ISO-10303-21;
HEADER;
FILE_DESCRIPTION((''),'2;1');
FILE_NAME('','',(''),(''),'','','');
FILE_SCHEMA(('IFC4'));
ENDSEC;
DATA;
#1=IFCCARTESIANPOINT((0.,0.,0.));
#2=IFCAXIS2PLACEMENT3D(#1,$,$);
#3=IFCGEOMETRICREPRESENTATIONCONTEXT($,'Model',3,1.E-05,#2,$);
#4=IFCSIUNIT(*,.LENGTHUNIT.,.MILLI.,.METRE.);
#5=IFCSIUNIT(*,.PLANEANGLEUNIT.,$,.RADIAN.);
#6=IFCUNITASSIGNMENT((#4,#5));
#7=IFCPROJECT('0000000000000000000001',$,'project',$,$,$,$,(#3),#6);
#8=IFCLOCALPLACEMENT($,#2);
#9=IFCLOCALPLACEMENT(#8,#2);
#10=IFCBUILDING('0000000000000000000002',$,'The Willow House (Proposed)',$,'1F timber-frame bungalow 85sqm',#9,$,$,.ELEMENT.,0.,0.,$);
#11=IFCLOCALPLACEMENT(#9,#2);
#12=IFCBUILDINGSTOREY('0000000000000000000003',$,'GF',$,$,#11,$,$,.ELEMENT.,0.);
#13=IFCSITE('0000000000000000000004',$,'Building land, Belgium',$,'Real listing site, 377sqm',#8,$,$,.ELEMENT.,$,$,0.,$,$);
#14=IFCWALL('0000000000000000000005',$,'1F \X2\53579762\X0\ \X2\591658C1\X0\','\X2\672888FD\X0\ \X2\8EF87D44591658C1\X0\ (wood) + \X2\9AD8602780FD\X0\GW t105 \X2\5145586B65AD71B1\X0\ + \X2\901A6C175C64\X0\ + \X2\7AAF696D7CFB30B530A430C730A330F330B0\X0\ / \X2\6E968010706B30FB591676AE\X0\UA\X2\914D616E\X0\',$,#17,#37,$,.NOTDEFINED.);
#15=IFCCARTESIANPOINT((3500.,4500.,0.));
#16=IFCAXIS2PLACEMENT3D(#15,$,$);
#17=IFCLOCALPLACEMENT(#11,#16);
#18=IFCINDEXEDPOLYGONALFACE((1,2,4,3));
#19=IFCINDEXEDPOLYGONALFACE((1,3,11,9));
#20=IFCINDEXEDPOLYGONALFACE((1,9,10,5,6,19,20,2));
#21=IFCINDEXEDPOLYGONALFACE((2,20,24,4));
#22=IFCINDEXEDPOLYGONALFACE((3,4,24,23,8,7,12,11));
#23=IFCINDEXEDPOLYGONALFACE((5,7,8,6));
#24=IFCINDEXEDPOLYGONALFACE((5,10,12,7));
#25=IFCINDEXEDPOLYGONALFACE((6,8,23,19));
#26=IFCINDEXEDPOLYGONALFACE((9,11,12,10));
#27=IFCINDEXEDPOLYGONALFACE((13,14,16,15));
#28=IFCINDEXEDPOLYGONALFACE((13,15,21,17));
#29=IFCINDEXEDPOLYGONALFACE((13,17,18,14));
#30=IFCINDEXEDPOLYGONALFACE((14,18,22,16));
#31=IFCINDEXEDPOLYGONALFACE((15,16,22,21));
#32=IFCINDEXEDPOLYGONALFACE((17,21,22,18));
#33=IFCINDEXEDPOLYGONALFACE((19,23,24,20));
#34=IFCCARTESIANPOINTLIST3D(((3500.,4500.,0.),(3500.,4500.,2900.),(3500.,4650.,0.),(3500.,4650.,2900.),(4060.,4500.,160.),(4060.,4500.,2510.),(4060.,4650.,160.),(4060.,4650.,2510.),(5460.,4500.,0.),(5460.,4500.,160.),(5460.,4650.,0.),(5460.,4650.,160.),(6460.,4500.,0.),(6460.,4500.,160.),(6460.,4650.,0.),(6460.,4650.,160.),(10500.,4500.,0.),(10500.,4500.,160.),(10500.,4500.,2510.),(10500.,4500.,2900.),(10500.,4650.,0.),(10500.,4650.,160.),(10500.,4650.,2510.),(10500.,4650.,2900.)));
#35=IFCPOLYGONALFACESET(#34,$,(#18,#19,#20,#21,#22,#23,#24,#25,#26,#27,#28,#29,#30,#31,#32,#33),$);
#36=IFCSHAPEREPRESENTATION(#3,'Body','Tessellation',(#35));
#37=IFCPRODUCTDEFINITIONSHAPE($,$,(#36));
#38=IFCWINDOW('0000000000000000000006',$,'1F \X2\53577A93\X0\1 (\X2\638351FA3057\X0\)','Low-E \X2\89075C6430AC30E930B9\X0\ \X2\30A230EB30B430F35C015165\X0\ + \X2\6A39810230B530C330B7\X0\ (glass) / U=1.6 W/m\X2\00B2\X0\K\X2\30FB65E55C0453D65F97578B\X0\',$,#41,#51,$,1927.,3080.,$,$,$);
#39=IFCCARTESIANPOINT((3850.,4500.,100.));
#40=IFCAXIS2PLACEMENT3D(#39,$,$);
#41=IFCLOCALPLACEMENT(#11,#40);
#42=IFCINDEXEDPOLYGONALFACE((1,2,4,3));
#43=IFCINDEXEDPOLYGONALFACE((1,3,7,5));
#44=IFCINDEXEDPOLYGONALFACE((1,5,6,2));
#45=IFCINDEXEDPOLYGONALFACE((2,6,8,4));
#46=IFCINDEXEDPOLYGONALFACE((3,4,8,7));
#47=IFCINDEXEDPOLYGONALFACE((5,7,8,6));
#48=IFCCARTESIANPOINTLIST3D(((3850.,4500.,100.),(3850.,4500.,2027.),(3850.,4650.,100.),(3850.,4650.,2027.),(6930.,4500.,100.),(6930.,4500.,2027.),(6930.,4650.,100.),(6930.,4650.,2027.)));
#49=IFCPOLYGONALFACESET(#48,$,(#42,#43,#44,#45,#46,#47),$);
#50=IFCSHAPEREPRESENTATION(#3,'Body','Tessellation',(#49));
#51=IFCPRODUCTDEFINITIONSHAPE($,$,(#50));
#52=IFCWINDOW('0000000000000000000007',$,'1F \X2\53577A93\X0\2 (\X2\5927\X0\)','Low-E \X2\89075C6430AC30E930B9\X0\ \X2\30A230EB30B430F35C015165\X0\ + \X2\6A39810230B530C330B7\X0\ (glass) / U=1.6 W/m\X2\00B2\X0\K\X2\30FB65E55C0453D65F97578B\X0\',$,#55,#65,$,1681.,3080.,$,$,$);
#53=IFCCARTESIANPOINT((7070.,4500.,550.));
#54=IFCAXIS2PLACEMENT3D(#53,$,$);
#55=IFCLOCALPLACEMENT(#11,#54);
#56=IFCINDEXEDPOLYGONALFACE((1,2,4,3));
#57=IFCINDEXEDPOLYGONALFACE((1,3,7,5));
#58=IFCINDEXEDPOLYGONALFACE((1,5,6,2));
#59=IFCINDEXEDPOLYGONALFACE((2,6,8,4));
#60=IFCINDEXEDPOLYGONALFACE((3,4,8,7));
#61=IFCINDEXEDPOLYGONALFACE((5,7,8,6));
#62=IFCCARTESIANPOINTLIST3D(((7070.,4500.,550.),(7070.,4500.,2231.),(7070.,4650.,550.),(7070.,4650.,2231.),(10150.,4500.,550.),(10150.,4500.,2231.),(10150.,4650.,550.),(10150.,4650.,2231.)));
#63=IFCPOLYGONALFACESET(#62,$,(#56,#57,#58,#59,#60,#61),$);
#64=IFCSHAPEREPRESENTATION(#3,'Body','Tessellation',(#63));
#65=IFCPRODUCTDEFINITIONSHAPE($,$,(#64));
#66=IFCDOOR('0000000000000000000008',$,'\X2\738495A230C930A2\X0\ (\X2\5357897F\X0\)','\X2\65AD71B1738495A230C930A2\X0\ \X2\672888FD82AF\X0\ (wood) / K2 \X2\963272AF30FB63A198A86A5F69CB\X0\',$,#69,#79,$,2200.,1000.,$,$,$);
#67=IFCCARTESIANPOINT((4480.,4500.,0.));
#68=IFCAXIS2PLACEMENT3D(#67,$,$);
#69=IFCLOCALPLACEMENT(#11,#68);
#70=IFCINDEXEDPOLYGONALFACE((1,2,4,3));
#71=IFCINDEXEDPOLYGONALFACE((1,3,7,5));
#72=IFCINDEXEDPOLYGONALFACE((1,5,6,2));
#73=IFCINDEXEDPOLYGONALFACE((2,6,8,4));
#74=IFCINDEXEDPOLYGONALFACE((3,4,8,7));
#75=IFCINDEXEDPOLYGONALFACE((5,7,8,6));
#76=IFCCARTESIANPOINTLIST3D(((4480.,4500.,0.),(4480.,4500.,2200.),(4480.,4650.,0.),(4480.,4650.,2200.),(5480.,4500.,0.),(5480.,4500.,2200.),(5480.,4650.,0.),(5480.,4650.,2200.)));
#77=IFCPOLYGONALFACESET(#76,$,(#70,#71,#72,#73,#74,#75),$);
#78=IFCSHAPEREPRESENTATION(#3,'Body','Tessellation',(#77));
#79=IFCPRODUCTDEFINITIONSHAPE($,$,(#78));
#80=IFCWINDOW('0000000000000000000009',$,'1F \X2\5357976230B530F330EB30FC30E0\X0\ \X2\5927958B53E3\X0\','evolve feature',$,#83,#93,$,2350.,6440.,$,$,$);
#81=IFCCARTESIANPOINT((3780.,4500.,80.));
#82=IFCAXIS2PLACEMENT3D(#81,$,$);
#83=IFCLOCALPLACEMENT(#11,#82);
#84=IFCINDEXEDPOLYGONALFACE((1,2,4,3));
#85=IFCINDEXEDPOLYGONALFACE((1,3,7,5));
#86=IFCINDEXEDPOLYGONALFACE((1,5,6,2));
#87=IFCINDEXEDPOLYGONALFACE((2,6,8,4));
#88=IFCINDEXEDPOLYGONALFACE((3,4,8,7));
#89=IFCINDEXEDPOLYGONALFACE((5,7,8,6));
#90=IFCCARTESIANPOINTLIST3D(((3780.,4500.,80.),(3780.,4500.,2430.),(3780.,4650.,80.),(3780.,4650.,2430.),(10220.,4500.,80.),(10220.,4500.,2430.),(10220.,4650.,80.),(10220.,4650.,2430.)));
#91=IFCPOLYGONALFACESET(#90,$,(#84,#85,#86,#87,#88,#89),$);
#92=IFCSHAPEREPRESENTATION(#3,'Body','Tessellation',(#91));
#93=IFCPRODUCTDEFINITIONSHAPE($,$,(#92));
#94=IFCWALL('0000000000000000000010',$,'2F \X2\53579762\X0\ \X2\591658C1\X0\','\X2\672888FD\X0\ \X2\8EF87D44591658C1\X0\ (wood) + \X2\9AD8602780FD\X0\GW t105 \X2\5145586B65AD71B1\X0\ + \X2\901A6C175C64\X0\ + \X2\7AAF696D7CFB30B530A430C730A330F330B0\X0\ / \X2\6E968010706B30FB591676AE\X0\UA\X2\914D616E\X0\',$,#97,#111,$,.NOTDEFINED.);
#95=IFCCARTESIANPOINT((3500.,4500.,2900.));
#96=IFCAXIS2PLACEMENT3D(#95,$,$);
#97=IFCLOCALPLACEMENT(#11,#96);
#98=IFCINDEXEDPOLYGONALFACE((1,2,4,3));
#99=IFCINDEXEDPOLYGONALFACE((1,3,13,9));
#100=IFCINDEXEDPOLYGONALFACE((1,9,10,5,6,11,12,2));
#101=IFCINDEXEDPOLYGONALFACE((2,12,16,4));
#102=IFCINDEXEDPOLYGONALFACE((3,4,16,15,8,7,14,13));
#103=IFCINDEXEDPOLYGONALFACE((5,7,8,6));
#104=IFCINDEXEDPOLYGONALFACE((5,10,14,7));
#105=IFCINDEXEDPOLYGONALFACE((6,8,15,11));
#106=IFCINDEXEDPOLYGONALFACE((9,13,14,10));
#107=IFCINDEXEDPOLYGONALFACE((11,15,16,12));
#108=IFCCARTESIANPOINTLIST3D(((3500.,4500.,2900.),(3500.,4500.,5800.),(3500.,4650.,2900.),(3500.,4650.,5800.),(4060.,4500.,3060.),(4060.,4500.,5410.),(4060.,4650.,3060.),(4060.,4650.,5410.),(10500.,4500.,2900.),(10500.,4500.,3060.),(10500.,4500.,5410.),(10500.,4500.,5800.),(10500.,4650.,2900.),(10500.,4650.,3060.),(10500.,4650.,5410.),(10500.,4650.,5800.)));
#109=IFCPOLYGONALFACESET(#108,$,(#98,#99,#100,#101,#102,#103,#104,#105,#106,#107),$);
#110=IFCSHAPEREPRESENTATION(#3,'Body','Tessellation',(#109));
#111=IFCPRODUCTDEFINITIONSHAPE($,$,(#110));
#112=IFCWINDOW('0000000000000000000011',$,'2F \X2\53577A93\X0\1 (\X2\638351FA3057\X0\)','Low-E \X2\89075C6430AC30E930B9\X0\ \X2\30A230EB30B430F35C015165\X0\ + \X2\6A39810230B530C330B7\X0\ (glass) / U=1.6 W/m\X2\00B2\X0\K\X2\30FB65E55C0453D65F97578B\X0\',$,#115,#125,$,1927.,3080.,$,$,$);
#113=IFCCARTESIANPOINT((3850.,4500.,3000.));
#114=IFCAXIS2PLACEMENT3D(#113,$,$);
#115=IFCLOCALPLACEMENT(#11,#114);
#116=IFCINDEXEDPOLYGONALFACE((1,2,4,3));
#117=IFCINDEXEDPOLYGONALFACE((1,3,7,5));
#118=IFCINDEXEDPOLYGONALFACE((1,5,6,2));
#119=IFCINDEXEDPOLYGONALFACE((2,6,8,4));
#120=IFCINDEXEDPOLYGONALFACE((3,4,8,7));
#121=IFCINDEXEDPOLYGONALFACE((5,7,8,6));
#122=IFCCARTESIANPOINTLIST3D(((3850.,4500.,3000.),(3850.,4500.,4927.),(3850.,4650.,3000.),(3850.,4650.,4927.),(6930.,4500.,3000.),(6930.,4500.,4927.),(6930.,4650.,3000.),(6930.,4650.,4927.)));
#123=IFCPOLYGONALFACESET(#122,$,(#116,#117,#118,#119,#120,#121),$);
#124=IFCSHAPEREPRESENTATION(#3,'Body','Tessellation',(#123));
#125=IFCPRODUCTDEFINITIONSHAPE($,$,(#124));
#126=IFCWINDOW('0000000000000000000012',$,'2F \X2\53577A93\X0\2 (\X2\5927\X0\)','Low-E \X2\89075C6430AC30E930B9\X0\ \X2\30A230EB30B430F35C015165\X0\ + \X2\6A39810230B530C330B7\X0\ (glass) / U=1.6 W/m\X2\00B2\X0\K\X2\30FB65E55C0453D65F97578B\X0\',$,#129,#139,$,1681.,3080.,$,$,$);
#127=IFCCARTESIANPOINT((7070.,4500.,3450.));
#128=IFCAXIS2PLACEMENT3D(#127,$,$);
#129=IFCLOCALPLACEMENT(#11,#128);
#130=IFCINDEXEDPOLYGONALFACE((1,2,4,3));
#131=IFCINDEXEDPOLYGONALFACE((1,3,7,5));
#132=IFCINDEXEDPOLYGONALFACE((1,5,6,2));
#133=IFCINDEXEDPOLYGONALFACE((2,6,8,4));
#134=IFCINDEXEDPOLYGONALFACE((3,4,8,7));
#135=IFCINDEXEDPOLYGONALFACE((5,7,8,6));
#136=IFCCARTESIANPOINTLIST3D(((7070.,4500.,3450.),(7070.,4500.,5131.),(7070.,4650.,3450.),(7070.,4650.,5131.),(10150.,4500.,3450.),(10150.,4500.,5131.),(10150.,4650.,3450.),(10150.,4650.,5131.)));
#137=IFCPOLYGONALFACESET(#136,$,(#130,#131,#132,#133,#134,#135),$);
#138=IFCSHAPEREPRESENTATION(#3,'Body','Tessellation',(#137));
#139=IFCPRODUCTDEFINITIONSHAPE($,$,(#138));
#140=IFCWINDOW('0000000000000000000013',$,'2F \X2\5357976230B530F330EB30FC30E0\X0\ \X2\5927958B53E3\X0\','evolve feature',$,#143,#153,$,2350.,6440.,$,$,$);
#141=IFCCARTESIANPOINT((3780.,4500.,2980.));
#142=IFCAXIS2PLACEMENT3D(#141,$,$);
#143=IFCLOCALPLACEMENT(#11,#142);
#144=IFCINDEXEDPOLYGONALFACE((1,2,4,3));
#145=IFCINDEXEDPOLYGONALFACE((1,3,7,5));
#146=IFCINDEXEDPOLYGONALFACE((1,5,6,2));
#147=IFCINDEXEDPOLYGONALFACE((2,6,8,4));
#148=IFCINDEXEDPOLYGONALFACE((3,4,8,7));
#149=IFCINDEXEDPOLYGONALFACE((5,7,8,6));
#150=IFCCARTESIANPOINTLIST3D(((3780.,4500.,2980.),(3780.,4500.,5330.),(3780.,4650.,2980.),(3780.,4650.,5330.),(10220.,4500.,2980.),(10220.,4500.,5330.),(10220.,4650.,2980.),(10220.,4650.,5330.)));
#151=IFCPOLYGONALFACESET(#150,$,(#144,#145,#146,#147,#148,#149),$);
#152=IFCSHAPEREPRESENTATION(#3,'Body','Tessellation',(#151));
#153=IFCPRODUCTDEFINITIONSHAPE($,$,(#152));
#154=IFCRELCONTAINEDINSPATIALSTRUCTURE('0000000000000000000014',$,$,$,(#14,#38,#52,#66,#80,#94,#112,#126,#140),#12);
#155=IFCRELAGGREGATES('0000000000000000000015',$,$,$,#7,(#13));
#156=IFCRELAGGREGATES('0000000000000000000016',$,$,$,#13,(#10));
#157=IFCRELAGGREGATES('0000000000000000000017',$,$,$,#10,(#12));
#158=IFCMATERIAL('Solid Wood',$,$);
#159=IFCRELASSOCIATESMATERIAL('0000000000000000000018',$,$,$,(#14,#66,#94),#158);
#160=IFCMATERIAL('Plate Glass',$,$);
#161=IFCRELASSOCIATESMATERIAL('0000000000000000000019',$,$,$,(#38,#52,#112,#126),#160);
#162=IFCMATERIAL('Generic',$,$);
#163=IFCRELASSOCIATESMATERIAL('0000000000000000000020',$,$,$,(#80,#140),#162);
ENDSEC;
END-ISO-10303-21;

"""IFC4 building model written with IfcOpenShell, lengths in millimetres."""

from ifc_helpers import new_model, si_unit, frame, frame_2d, origin, place, context, project, spatial, rectangle, extrude, material, element, fill, save


model = new_model("IFC4")

# Units and contexts
model_context = context("Model", 3, precision=1e-05, world=origin())
ifc_project = project(units=[si_unit("LENGTHUNIT", "METRE", prefix="MILLI"), si_unit("PLANEANGLEUNIT", "RADIAN")], contexts=[model_context])

# Site, building, storey
site_placement = place(None, origin())
site = spatial("IfcSite", under=ifc_project, at=site_placement, Name="Building land, Belgium", ObjectType="Real listing site, 377sqm", CompositionType="ELEMENT", RefElevation=0.0)
building_placement = place(site_placement, origin())
building = spatial("IfcBuilding", under=site, at=building_placement, Name="The Willow House (Proposed)", ObjectType="1F timber-frame bungalow 85sqm", CompositionType="ELEMENT", ElevationOfRefHeight=0.0, ElevationOfTerrain=0.0)
storey_placement = place(building_placement, origin())
storey = spatial("IfcBuildingStorey", under=building, at=storey_placement, Name="GF", CompositionType="ELEMENT", Elevation=0.0)

# Shared definitions
ifc_material_1 = material(Name="Solid Wood")
ifc_material_2 = material(Name="Generic")

# Wall, openings, windows, door
wall_1_placement = place(storey_placement, frame((3500.0, 4500.0, 0.0)))
wall_1 = element("IfcWall", 1, at=wall_1_placement, inside=storey, material=ifc_material_1, Name="1F 南面 外壁", Description="木製 軸組外壁 (wood) + 高性能GW t105 充填断熱 + 通気層 + 窯業系サイディング / 準耐火・外皮UA配慮", PredefinedType="NOTDEFINED", context=model_context, shape_type="SweptSolid", body=[
    extrude(rectangle(XDim=7000.0, YDim=150.0, at=frame_2d((3500.0, 75.0))), frame((3500.0, 4500.0, 0.0)), (0.0, 0.0, 1.0), 2900.0),
])
opening_1_placement = place(storey_placement, frame((3850.0, 4500.0, 100.0)))
opening_1 = element("IfcOpeningElement", 2, at=opening_1_placement, cuts=wall_1, PredefinedType="NOTDEFINED", context=model_context, shape_type="SweptSolid", body=[
    extrude(rectangle(XDim=3080.0, YDim=150.0, at=frame_2d((1540.0, 75.0))), frame((3850.0, 4500.0, 100.0)), (0.0, 0.0, 1.0), 1927.0),
])
opening_2_placement = place(storey_placement, frame((7070.0, 4500.0, 550.0)))
opening_2 = element("IfcOpeningElement", 3, at=opening_2_placement, cuts=wall_1, PredefinedType="NOTDEFINED", context=model_context, shape_type="SweptSolid", body=[
    extrude(rectangle(XDim=3080.0, YDim=150.0, at=frame_2d((1540.0, 75.0))), frame((7070.0, 4500.0, 550.0)), (0.0, 0.0, 1.0), 1681.0),
])
opening_3_placement = place(storey_placement, frame((4480.0, 4500.0, 0.0)))
opening_3 = element("IfcOpeningElement", 4, at=opening_3_placement, cuts=wall_1, PredefinedType="NOTDEFINED", context=model_context, shape_type="SweptSolid", body=[
    extrude(rectangle(XDim=1000.0, YDim=150.0, at=frame_2d((500.0, 75.0))), frame((4480.0, 4500.0, 0.0)), (0.0, 0.0, 1.0), 2200.0),
])
opening_4_placement = place(storey_placement, frame((3780.0, 4500.0, 80.0)))
opening_4 = element("IfcOpeningElement", 5, at=opening_4_placement, cuts=wall_1, PredefinedType="NOTDEFINED", context=model_context, shape_type="SweptSolid", body=[
    extrude(rectangle(XDim=6440.0, YDim=150.0, at=frame_2d((3220.0, 75.0))), frame((3780.0, 4500.0, 80.0)), (0.0, 0.0, 1.0), 2350.0),
])
ifc_material_3 = material(Name="Plate Glass")
window_1_placement = place(storey_placement, frame((3850.0, 4500.0, 100.0)))
window_1 = element("IfcWindow", 6, at=window_1_placement, inside=storey, material=ifc_material_3, Name="1F 南窓1 (掃出し)", Description="Low-E 複層ガラス アルゴン封入 + 樹脂サッシ (glass) / U=1.6 W/m²K・日射取得型", OverallHeight=1927.0, OverallWidth=3080.0, context=model_context, shape_type="SweptSolid", body=[
    extrude(rectangle(XDim=3080.0, YDim=150.0, at=frame_2d((1540.0, 75.0))), frame((3850.0, 4500.0, 100.0)), (0.0, 0.0, 1.0), 1927.0),
])
fill(opening_1, window_1)
window_2_placement = place(storey_placement, frame((7070.0, 4500.0, 550.0)))
window_2 = element("IfcWindow", 7, at=window_2_placement, inside=storey, material=ifc_material_3, Name="1F 南窓2 (大)", Description="Low-E 複層ガラス アルゴン封入 + 樹脂サッシ (glass) / U=1.6 W/m²K・日射取得型", OverallHeight=1681.0, OverallWidth=3080.0, context=model_context, shape_type="SweptSolid", body=[
    extrude(rectangle(XDim=3080.0, YDim=150.0, at=frame_2d((1540.0, 75.0))), frame((7070.0, 4500.0, 550.0)), (0.0, 0.0, 1.0), 1681.0),
])
fill(opening_2, window_2)
door_placement = place(storey_placement, frame((4480.0, 4500.0, 0.0)))
door = element("IfcDoor", 8, at=door_placement, inside=storey, material=ifc_material_1, Name="玄関ドア (南西)", Description="断熱玄関ドア 木製芯 (wood) / K2 防犯・採風機構", OverallHeight=2200.0, OverallWidth=1000.0, context=model_context, shape_type="SweptSolid", body=[
    extrude(rectangle(XDim=1000.0, YDim=150.0, at=frame_2d((500.0, 75.0))), frame((4480.0, 4500.0, 0.0)), (0.0, 0.0, 1.0), 2200.0),
])
fill(opening_3, door)
window_3_placement = place(storey_placement, frame((3780.0, 4500.0, 80.0)))
window_3 = element("IfcWindow", 9, at=window_3_placement, inside=storey, material=ifc_material_2, Name="1F 南面サンルーム 大開口", Description="evolve feature", OverallHeight=2350.0, OverallWidth=6440.0, context=model_context, shape_type="SweptSolid", body=[
    extrude(rectangle(XDim=6440.0, YDim=150.0, at=frame_2d((3220.0, 75.0))), frame((3780.0, 4500.0, 80.0)), (0.0, 0.0, 1.0), 2350.0),
])
fill(opening_4, window_3)

# Wall, openings, windows
wall_2_placement = place(storey_placement, frame((3500.0, 4500.0, 2900.0)))
wall_2 = element("IfcWall", 10, at=wall_2_placement, inside=storey, material=ifc_material_1, Name="2F 南面 外壁", Description="木製 軸組外壁 (wood) + 高性能GW t105 充填断熱 + 通気層 + 窯業系サイディング / 準耐火・外皮UA配慮", PredefinedType="NOTDEFINED", context=model_context, shape_type="SweptSolid", body=[
    extrude(rectangle(XDim=7000.0, YDim=150.0, at=frame_2d((3500.0, 75.0))), frame((3500.0, 4500.0, 2900.0)), (0.0, 0.0, 1.0), 2900.0),
])
opening_5_placement = place(storey_placement, frame((3850.0, 4500.0, 3000.0)))
opening_5 = element("IfcOpeningElement", 11, at=opening_5_placement, cuts=wall_2, PredefinedType="NOTDEFINED", context=model_context, shape_type="SweptSolid", body=[
    extrude(rectangle(XDim=3080.0, YDim=150.0, at=frame_2d((1540.0, 75.0))), frame((3850.0, 4500.0, 3000.0)), (0.0, 0.0, 1.0), 1927.0),
])
opening_6_placement = place(storey_placement, frame((7070.0, 4500.0, 3450.0)))
opening_6 = element("IfcOpeningElement", 12, at=opening_6_placement, cuts=wall_2, PredefinedType="NOTDEFINED", context=model_context, shape_type="SweptSolid", body=[
    extrude(rectangle(XDim=3080.0, YDim=150.0, at=frame_2d((1540.0, 75.0))), frame((7070.0, 4500.0, 3450.0)), (0.0, 0.0, 1.0), 1681.0),
])
opening_7_placement = place(storey_placement, frame((3780.0, 4500.0, 2980.0)))
opening_7 = element("IfcOpeningElement", 13, at=opening_7_placement, cuts=wall_2, PredefinedType="NOTDEFINED", context=model_context, shape_type="SweptSolid", body=[
    extrude(rectangle(XDim=6440.0, YDim=150.0, at=frame_2d((3220.0, 75.0))), frame((3780.0, 4500.0, 2980.0)), (0.0, 0.0, 1.0), 2350.0),
])
window_4_placement = place(storey_placement, frame((3850.0, 4500.0, 3000.0)))
window_4 = element("IfcWindow", 14, at=window_4_placement, inside=storey, material=ifc_material_3, Name="2F 南窓1 (掃出し)", Description="Low-E 複層ガラス アルゴン封入 + 樹脂サッシ (glass) / U=1.6 W/m²K・日射取得型", OverallHeight=1927.0, OverallWidth=3080.0, context=model_context, shape_type="SweptSolid", body=[
    extrude(rectangle(XDim=3080.0, YDim=150.0, at=frame_2d((1540.0, 75.0))), frame((3850.0, 4500.0, 3000.0)), (0.0, 0.0, 1.0), 1927.0),
])
fill(opening_5, window_4)
window_5_placement = place(storey_placement, frame((7070.0, 4500.0, 3450.0)))
window_5 = element("IfcWindow", 15, at=window_5_placement, inside=storey, material=ifc_material_3, Name="2F 南窓2 (大)", Description="Low-E 複層ガラス アルゴン封入 + 樹脂サッシ (glass) / U=1.6 W/m²K・日射取得型", OverallHeight=1681.0, OverallWidth=3080.0, context=model_context, shape_type="SweptSolid", body=[
    extrude(rectangle(XDim=3080.0, YDim=150.0, at=frame_2d((1540.0, 75.0))), frame((7070.0, 4500.0, 3450.0)), (0.0, 0.0, 1.0), 1681.0),
])
fill(opening_6, window_5)
window_6_placement = place(storey_placement, frame((3780.0, 4500.0, 2980.0)))
window_6 = element("IfcWindow", 16, at=window_6_placement, inside=storey, material=ifc_material_2, Name="2F 南面サンルーム 大開口", Description="evolve feature", OverallHeight=2350.0, OverallWidth=6440.0, context=model_context, shape_type="SweptSolid", body=[
    extrude(rectangle(XDim=6440.0, YDim=150.0, at=frame_2d((3220.0, 75.0))), frame((3780.0, 4500.0, 2980.0)), (0.0, 0.0, 1.0), 2350.0),
])
fill(opening_7, window_6)

save(model, "model.ifc")
